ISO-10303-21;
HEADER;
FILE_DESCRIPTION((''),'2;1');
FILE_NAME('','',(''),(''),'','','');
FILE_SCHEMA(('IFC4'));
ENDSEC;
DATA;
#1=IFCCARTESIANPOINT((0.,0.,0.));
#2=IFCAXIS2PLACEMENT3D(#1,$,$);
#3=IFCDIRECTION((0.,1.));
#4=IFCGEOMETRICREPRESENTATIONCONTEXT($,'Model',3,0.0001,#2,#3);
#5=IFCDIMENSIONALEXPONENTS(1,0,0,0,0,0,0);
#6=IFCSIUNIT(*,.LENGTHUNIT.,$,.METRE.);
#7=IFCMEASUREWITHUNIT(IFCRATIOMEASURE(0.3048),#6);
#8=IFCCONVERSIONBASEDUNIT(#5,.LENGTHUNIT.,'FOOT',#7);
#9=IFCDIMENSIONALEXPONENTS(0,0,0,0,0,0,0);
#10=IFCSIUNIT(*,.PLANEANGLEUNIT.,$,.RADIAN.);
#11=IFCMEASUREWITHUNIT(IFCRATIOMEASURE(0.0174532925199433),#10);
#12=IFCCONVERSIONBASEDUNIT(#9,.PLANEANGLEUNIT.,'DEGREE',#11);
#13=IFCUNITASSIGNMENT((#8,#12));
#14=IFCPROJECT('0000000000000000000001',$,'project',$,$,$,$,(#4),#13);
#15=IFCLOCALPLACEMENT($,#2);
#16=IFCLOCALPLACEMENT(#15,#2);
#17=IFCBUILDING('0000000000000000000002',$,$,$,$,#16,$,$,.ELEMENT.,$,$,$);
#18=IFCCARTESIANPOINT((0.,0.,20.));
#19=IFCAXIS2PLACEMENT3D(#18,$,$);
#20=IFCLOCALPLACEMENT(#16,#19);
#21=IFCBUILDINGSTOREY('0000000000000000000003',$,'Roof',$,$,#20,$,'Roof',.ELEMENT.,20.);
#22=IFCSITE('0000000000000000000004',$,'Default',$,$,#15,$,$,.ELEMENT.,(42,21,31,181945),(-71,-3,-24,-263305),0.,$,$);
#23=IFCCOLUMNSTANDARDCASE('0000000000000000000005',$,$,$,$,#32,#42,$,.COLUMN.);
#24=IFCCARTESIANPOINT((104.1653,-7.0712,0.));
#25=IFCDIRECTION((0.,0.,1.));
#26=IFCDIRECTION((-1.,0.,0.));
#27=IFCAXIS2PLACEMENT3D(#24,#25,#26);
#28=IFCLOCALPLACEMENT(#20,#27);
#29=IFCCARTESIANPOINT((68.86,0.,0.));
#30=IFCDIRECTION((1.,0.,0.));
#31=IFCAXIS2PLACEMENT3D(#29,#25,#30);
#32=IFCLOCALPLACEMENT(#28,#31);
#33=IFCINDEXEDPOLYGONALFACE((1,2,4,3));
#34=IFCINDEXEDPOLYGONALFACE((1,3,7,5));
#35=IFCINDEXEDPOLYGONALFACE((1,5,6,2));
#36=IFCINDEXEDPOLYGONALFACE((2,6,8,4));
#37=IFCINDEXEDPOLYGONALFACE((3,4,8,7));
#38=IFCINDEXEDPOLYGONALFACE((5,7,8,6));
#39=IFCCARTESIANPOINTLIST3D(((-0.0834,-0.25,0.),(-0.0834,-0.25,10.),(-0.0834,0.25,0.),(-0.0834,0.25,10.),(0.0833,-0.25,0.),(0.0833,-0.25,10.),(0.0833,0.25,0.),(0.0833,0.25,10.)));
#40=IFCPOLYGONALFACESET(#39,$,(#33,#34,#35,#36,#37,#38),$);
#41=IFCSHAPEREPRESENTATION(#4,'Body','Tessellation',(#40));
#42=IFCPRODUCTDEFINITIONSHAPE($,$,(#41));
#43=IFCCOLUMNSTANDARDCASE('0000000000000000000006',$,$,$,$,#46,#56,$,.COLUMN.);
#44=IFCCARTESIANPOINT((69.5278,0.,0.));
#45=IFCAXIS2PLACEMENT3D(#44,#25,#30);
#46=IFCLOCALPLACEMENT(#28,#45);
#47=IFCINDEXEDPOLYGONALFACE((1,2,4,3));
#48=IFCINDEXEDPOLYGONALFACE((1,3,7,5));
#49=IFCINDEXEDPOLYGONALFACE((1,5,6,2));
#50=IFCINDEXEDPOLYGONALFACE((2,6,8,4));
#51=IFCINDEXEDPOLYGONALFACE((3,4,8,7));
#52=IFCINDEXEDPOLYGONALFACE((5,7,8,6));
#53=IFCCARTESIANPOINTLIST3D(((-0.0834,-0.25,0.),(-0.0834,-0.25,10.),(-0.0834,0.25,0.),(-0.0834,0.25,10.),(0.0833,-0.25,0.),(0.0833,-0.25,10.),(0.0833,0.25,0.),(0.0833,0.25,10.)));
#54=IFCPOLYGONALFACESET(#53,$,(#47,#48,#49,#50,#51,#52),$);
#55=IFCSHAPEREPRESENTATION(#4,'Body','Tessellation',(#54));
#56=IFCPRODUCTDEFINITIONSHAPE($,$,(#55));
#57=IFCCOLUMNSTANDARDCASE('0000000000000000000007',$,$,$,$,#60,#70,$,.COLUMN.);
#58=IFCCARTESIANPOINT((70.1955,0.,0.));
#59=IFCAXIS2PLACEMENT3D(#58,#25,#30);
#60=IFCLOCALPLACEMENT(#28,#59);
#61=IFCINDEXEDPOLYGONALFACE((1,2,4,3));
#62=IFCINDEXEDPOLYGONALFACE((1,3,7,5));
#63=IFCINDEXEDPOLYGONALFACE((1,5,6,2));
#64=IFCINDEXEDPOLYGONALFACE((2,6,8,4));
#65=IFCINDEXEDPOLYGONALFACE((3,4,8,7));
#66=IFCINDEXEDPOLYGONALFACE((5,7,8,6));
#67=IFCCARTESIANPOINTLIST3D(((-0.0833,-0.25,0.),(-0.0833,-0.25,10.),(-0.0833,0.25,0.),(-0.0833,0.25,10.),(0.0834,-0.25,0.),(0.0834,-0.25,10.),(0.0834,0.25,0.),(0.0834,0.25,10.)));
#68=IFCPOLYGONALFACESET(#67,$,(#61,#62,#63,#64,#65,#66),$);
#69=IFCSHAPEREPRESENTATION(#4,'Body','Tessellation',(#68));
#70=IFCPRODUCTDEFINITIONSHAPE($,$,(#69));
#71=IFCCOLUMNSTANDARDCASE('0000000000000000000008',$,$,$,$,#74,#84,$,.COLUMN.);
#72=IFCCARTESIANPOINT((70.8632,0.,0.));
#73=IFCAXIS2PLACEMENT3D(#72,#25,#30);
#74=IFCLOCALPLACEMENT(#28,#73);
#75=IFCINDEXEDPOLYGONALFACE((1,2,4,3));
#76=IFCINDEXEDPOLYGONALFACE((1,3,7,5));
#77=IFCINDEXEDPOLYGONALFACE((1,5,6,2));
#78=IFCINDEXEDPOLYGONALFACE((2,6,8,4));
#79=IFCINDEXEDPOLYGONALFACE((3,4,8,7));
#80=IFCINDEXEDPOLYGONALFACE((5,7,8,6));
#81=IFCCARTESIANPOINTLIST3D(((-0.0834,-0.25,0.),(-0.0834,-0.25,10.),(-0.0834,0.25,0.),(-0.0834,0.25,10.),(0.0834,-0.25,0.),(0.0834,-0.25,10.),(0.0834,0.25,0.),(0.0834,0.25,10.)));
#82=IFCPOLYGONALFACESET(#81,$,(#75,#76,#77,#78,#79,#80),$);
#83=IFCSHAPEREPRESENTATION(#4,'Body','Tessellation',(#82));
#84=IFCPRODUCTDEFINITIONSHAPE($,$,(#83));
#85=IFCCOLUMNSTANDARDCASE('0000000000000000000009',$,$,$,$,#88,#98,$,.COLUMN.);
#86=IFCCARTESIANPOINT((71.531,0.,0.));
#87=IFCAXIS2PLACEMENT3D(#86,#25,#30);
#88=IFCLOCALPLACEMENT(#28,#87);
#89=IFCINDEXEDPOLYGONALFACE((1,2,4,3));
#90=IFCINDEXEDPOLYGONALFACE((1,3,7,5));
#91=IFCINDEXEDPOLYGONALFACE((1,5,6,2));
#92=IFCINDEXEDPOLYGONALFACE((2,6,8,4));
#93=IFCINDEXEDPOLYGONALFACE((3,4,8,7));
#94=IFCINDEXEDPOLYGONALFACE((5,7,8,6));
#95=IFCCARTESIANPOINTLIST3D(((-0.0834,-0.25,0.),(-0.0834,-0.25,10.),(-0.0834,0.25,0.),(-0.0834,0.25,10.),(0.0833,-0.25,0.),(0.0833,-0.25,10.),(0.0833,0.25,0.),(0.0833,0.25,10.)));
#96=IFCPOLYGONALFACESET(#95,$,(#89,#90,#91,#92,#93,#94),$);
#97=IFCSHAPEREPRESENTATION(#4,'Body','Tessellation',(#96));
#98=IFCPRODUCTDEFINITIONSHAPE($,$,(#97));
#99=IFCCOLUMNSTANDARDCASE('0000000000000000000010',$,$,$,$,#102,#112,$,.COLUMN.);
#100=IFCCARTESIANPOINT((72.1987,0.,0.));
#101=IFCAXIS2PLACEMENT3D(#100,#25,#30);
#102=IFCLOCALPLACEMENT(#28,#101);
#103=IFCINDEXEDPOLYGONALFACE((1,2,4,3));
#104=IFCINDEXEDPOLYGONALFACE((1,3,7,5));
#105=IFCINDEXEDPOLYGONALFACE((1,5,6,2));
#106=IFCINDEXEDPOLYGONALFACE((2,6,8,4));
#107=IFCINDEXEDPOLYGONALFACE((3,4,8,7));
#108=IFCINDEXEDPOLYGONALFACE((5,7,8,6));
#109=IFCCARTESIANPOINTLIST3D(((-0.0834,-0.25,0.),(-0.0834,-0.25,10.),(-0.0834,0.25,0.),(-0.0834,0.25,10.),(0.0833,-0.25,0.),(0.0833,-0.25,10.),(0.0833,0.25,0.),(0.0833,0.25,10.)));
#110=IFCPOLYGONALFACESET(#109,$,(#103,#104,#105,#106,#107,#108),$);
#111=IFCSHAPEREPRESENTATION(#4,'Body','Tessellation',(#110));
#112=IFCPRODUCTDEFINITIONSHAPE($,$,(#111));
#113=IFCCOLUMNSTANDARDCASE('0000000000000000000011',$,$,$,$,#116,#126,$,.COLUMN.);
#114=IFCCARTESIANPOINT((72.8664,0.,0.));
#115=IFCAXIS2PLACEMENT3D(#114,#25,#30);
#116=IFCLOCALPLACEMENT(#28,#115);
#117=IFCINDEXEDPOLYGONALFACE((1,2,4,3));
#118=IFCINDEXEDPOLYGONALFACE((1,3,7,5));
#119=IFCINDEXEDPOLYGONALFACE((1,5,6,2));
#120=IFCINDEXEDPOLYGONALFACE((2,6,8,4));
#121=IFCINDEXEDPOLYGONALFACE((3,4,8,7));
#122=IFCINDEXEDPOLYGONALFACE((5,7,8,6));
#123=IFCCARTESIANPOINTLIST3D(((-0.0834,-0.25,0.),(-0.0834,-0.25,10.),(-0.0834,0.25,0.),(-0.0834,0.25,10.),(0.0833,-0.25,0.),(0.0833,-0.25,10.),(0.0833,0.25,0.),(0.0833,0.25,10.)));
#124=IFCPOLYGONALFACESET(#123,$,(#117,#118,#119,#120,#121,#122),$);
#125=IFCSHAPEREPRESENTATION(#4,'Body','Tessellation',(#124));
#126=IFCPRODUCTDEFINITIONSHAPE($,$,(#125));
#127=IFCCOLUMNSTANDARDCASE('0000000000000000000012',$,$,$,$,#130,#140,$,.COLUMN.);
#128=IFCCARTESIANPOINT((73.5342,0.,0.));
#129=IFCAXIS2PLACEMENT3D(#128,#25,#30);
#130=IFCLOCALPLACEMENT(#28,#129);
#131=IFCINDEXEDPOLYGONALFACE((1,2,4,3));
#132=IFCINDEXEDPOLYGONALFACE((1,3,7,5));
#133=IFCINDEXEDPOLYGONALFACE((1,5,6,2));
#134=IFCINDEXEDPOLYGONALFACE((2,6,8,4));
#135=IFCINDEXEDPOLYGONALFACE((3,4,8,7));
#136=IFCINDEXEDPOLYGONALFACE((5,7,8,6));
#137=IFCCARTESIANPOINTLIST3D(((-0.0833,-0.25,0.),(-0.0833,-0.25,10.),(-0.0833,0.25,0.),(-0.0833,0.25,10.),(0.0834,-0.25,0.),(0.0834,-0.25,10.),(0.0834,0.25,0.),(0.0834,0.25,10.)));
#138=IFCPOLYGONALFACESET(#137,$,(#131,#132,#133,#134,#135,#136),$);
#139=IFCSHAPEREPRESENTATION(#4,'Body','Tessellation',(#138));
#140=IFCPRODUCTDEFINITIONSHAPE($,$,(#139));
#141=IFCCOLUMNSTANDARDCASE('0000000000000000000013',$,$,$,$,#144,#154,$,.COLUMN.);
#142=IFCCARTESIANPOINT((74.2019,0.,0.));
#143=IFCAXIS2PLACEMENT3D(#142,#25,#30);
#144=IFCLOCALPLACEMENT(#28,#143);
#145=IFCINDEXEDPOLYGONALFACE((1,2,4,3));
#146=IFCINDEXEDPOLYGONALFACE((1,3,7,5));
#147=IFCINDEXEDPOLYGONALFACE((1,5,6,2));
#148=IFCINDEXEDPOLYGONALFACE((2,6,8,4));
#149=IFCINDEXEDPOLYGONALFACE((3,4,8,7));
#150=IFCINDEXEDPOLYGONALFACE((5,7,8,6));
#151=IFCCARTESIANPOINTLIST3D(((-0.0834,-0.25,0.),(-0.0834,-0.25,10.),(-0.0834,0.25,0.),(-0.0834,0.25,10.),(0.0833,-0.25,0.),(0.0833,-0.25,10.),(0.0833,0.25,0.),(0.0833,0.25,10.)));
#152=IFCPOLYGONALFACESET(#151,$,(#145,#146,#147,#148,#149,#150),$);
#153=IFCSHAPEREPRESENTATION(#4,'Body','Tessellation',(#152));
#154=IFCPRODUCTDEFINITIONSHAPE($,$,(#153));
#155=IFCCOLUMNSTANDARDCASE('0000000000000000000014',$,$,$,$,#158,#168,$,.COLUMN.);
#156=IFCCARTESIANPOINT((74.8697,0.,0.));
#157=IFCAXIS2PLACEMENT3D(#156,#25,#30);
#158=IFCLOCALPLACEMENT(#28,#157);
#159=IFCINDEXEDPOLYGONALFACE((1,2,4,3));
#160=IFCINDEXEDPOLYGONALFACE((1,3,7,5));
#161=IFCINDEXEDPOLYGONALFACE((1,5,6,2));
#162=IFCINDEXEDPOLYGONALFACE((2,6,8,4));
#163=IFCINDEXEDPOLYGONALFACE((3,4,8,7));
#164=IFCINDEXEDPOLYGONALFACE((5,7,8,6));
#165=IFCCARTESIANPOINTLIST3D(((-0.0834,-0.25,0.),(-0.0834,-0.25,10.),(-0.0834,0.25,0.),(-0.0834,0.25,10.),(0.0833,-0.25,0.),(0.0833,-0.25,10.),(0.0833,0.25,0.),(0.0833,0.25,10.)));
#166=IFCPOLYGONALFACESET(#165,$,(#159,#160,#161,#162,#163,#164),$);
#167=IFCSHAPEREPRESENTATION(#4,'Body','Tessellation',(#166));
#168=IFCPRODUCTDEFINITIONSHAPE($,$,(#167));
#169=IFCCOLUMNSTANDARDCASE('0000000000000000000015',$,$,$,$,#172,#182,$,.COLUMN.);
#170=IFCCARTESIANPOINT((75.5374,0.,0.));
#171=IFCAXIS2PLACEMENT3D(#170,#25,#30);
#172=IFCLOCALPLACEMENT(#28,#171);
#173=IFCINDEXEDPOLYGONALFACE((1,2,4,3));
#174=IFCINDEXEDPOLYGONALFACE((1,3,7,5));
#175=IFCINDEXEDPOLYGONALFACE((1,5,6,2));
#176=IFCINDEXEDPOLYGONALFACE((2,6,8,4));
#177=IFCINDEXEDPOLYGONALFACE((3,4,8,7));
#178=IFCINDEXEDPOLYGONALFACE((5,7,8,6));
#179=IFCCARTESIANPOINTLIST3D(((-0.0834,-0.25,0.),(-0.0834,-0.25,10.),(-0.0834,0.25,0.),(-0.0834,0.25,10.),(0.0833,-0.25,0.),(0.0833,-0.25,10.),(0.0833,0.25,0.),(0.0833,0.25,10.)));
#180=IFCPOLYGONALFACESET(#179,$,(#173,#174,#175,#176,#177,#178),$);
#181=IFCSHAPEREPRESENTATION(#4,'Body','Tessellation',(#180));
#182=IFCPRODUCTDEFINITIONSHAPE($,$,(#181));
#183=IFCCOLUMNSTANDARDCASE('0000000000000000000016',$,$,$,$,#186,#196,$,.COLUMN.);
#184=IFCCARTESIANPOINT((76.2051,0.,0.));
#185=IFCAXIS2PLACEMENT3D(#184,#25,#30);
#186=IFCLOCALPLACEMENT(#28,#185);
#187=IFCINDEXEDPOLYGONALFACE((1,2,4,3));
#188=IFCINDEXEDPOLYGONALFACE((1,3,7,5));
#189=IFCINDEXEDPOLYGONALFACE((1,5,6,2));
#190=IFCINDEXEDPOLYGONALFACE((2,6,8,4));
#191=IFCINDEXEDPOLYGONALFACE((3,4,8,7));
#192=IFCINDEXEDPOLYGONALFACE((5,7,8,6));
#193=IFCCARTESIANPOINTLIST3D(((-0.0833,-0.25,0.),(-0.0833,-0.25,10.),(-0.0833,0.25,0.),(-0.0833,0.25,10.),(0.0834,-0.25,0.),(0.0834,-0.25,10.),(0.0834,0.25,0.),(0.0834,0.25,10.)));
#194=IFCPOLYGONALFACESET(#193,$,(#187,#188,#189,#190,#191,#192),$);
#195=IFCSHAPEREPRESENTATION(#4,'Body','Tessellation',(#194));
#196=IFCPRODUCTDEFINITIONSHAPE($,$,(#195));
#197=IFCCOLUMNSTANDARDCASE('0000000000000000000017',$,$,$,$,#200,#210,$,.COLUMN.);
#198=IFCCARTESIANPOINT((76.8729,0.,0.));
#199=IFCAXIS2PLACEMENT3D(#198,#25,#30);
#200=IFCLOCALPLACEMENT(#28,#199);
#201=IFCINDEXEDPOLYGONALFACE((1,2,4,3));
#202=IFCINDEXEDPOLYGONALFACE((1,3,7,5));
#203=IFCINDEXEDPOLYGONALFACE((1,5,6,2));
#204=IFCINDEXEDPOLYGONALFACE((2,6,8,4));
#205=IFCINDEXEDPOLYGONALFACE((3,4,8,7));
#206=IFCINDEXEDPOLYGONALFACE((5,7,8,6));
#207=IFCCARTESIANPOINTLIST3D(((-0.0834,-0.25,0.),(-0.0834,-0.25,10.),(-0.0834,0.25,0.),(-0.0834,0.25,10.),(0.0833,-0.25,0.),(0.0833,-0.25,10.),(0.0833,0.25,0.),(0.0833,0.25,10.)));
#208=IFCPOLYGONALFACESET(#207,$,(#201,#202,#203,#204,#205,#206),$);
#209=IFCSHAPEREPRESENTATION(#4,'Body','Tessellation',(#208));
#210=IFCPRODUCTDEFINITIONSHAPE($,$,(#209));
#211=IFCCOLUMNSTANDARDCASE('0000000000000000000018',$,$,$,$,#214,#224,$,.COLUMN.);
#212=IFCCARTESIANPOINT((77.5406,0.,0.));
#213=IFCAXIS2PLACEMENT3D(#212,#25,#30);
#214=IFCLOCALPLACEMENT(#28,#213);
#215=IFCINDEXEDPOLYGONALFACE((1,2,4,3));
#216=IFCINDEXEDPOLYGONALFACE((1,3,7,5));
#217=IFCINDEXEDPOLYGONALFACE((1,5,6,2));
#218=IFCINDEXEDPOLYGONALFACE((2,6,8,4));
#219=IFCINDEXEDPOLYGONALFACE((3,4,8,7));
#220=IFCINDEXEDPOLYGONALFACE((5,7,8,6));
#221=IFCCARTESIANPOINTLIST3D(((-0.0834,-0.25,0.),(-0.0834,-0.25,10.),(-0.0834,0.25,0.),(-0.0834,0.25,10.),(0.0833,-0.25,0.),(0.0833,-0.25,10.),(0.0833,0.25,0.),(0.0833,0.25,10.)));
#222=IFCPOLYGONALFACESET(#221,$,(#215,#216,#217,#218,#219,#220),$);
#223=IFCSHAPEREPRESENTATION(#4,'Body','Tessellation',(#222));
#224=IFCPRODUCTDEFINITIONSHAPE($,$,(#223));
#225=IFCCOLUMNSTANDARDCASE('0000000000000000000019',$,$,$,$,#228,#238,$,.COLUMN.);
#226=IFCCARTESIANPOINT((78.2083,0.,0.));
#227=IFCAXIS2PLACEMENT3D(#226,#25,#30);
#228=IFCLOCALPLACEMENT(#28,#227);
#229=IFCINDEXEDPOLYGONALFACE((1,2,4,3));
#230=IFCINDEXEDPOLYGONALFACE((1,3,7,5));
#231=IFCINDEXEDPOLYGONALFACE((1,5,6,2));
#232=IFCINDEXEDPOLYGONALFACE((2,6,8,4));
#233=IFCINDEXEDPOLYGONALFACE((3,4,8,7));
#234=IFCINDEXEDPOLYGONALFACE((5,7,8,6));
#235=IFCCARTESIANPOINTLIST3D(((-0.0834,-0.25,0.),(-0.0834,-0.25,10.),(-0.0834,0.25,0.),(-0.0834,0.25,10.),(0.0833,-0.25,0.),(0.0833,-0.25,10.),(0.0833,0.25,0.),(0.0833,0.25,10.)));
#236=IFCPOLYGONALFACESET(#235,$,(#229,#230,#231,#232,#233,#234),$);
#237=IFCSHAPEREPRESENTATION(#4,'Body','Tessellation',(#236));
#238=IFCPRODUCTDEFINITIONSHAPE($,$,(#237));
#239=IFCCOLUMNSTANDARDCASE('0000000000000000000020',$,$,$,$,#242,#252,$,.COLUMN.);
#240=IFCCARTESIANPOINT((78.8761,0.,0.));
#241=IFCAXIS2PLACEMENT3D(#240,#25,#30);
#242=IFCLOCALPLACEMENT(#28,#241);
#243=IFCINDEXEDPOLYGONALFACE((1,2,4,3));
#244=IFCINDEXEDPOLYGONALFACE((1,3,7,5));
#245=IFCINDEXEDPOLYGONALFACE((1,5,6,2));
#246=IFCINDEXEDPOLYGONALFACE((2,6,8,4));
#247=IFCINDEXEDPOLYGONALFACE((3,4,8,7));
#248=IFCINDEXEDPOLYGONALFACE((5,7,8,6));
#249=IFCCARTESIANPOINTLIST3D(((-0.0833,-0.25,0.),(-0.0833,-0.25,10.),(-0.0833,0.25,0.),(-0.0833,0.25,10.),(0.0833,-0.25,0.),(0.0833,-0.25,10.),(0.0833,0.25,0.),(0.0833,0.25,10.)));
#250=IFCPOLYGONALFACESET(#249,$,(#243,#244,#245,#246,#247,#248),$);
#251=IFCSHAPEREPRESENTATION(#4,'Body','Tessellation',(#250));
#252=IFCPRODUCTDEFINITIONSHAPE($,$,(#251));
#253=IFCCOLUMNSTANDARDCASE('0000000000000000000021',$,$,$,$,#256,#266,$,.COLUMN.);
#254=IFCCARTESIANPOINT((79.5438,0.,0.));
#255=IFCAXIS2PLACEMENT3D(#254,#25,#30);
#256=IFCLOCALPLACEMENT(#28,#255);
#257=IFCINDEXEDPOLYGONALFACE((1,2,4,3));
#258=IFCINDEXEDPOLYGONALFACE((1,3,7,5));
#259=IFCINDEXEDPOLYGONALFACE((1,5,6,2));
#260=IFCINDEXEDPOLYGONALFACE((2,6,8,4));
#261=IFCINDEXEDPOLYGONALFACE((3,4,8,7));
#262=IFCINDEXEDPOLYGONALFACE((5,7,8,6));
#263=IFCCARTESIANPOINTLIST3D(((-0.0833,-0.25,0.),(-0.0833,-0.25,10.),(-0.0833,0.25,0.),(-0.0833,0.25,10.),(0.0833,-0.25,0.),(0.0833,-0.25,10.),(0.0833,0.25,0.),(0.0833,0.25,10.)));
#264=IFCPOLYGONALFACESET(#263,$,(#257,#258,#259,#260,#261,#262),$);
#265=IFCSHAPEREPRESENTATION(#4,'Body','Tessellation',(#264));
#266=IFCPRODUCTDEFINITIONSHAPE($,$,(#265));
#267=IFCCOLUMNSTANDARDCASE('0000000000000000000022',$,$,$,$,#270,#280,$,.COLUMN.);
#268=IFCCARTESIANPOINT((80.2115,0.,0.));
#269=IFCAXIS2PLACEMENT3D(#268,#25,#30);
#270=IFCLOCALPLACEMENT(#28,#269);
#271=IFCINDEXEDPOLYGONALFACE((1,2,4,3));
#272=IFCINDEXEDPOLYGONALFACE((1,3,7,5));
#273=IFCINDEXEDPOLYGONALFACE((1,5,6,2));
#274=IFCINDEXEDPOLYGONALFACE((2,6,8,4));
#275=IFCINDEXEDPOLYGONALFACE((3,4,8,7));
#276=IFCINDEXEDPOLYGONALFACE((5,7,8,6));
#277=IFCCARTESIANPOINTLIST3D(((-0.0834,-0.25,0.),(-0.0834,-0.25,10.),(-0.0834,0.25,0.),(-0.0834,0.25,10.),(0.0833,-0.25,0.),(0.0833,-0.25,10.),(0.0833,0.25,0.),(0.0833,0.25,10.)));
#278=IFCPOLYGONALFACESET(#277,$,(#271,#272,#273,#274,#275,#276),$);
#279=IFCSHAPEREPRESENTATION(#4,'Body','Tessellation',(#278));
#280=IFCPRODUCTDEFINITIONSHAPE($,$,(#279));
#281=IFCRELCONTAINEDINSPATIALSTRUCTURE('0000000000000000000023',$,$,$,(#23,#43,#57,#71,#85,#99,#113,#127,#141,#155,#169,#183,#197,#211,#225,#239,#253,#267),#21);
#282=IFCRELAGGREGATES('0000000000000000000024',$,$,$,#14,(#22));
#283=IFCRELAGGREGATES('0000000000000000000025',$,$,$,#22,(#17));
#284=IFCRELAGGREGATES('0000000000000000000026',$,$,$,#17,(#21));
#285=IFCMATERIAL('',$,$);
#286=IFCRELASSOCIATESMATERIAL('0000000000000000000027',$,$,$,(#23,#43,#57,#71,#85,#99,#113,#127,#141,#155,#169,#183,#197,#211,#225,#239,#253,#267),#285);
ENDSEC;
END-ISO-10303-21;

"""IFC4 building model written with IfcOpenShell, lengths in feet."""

from ifc_helpers import new_model, entity, si_unit, converted_unit, direction, frame, origin, place, context, project, spatial, rectangle, extrude, material, element, save


model = new_model("IFC4")

# Units and contexts
model_context = context("Model", 3, precision=0.0001, world=origin(), true_north=direction((0.0, 1.0)))
ifc_project = project(units=[converted_unit("LENGTHUNIT", "FOOT", entity("IfcRatioMeasure", 0.3048), si_unit("LENGTHUNIT", "METRE"), dimensions=[1, 0, 0, 0, 0, 0, 0]), converted_unit("PLANEANGLEUNIT", "DEGREE", entity("IfcRatioMeasure", 0.0174532925199433), si_unit("PLANEANGLEUNIT", "RADIAN"), dimensions=[0, 0, 0, 0, 0, 0, 0])], contexts=[model_context])

# Site, building, storey
site_placement = place(None, origin())
site = spatial("IfcSite", under=ifc_project, at=site_placement, Name="Default", CompositionType="ELEMENT", RefLatitude=(42, 21, 31, 181945), RefLongitude=(-71, -3, -24, -263305), RefElevation=0.0)
building_placement = place(site_placement, origin())
building = spatial("IfcBuilding", under=site, at=building_placement, CompositionType="ELEMENT")
storey_placement = place(building_placement, frame((0.0, 0.0, 20.0)))
storey = spatial("IfcBuildingStorey", under=building, at=storey_placement, Name="Roof", LongName="Roof", CompositionType="ELEMENT", Elevation=20.0)

# Columns
ifc_material_1 = material(Name="")
placement = place(storey_placement, frame((104.1653, -7.0712, 0.0), z_axis=(0.0, 0.0, 1.0), x_axis=(-1.0, 0.0, 0.0)))
for number, where, z_axis, x_axis in (
    (1, (68.86, 0.0, 0.0), (0.0, 0.0, 1.0), (1.0, 0.0, 0.0)),
    (2, (69.5278, 0.0, 0.0), (0.0, 0.0, 1.0), (1.0, 0.0, 0.0)),
    (3, (70.1955, 0.0, 0.0), (0.0, 0.0, 1.0), (1.0, 0.0, 0.0)),
    (4, (70.8632, 0.0, 0.0), (0.0, 0.0, 1.0), (1.0, 0.0, 0.0)),
    (5, (71.531, 0.0, 0.0), (0.0, 0.0, 1.0), (1.0, 0.0, 0.0)),
    (6, (72.1987, 0.0, 0.0), (0.0, 0.0, 1.0), (1.0, 0.0, 0.0)),
    (7, (72.8664, 0.0, 0.0), (0.0, 0.0, 1.0), (1.0, 0.0, 0.0)),
    (8, (73.5342, 0.0, 0.0), (0.0, 0.0, 1.0), (1.0, 0.0, 0.0)),
    (9, (74.2019, 0.0, 0.0), (0.0, 0.0, 1.0), (1.0, 0.0, 0.0)),
    (10, (74.8697, 0.0, 0.0), (0.0, 0.0, 1.0), (1.0, 0.0, 0.0)),
    (11, (75.5374, 0.0, 0.0), (0.0, 0.0, 1.0), (1.0, 0.0, 0.0)),
    (12, (76.2051, 0.0, 0.0), (0.0, 0.0, 1.0), (1.0, 0.0, 0.0)),
    (13, (76.8729, 0.0, 0.0), (0.0, 0.0, 1.0), (1.0, 0.0, 0.0)),
    (14, (77.5406, 0.0, 0.0), (0.0, 0.0, 1.0), (1.0, 0.0, 0.0)),
    (15, (78.2083, 0.0, 0.0), (0.0, 0.0, 1.0), (1.0, 0.0, 0.0)),
    (16, (78.8761, 0.0, 0.0), (0.0, 0.0, 1.0), (1.0, 0.0, 0.0)),
    (17, (79.5438, 0.0, 0.0), (0.0, 0.0, 1.0), (1.0, 0.0, 0.0)),
    (18, (80.2115, 0.0, 0.0), (0.0, 0.0, 1.0), (1.0, 0.0, 0.0)),
):
    element("IfcColumnStandardCase", number, at=place(placement, frame(where, z_axis=z_axis, x_axis=x_axis)), inside=storey, material=ifc_material_1, PredefinedType="COLUMN", context=model_context, shape_type="SweptSolid", body=[
        extrude(rectangle(XDim=0.1667, YDim=0.5), origin(), (0.0, 0.0, 1.0), 10.0),
    ])

save(model, "model.ifc")
